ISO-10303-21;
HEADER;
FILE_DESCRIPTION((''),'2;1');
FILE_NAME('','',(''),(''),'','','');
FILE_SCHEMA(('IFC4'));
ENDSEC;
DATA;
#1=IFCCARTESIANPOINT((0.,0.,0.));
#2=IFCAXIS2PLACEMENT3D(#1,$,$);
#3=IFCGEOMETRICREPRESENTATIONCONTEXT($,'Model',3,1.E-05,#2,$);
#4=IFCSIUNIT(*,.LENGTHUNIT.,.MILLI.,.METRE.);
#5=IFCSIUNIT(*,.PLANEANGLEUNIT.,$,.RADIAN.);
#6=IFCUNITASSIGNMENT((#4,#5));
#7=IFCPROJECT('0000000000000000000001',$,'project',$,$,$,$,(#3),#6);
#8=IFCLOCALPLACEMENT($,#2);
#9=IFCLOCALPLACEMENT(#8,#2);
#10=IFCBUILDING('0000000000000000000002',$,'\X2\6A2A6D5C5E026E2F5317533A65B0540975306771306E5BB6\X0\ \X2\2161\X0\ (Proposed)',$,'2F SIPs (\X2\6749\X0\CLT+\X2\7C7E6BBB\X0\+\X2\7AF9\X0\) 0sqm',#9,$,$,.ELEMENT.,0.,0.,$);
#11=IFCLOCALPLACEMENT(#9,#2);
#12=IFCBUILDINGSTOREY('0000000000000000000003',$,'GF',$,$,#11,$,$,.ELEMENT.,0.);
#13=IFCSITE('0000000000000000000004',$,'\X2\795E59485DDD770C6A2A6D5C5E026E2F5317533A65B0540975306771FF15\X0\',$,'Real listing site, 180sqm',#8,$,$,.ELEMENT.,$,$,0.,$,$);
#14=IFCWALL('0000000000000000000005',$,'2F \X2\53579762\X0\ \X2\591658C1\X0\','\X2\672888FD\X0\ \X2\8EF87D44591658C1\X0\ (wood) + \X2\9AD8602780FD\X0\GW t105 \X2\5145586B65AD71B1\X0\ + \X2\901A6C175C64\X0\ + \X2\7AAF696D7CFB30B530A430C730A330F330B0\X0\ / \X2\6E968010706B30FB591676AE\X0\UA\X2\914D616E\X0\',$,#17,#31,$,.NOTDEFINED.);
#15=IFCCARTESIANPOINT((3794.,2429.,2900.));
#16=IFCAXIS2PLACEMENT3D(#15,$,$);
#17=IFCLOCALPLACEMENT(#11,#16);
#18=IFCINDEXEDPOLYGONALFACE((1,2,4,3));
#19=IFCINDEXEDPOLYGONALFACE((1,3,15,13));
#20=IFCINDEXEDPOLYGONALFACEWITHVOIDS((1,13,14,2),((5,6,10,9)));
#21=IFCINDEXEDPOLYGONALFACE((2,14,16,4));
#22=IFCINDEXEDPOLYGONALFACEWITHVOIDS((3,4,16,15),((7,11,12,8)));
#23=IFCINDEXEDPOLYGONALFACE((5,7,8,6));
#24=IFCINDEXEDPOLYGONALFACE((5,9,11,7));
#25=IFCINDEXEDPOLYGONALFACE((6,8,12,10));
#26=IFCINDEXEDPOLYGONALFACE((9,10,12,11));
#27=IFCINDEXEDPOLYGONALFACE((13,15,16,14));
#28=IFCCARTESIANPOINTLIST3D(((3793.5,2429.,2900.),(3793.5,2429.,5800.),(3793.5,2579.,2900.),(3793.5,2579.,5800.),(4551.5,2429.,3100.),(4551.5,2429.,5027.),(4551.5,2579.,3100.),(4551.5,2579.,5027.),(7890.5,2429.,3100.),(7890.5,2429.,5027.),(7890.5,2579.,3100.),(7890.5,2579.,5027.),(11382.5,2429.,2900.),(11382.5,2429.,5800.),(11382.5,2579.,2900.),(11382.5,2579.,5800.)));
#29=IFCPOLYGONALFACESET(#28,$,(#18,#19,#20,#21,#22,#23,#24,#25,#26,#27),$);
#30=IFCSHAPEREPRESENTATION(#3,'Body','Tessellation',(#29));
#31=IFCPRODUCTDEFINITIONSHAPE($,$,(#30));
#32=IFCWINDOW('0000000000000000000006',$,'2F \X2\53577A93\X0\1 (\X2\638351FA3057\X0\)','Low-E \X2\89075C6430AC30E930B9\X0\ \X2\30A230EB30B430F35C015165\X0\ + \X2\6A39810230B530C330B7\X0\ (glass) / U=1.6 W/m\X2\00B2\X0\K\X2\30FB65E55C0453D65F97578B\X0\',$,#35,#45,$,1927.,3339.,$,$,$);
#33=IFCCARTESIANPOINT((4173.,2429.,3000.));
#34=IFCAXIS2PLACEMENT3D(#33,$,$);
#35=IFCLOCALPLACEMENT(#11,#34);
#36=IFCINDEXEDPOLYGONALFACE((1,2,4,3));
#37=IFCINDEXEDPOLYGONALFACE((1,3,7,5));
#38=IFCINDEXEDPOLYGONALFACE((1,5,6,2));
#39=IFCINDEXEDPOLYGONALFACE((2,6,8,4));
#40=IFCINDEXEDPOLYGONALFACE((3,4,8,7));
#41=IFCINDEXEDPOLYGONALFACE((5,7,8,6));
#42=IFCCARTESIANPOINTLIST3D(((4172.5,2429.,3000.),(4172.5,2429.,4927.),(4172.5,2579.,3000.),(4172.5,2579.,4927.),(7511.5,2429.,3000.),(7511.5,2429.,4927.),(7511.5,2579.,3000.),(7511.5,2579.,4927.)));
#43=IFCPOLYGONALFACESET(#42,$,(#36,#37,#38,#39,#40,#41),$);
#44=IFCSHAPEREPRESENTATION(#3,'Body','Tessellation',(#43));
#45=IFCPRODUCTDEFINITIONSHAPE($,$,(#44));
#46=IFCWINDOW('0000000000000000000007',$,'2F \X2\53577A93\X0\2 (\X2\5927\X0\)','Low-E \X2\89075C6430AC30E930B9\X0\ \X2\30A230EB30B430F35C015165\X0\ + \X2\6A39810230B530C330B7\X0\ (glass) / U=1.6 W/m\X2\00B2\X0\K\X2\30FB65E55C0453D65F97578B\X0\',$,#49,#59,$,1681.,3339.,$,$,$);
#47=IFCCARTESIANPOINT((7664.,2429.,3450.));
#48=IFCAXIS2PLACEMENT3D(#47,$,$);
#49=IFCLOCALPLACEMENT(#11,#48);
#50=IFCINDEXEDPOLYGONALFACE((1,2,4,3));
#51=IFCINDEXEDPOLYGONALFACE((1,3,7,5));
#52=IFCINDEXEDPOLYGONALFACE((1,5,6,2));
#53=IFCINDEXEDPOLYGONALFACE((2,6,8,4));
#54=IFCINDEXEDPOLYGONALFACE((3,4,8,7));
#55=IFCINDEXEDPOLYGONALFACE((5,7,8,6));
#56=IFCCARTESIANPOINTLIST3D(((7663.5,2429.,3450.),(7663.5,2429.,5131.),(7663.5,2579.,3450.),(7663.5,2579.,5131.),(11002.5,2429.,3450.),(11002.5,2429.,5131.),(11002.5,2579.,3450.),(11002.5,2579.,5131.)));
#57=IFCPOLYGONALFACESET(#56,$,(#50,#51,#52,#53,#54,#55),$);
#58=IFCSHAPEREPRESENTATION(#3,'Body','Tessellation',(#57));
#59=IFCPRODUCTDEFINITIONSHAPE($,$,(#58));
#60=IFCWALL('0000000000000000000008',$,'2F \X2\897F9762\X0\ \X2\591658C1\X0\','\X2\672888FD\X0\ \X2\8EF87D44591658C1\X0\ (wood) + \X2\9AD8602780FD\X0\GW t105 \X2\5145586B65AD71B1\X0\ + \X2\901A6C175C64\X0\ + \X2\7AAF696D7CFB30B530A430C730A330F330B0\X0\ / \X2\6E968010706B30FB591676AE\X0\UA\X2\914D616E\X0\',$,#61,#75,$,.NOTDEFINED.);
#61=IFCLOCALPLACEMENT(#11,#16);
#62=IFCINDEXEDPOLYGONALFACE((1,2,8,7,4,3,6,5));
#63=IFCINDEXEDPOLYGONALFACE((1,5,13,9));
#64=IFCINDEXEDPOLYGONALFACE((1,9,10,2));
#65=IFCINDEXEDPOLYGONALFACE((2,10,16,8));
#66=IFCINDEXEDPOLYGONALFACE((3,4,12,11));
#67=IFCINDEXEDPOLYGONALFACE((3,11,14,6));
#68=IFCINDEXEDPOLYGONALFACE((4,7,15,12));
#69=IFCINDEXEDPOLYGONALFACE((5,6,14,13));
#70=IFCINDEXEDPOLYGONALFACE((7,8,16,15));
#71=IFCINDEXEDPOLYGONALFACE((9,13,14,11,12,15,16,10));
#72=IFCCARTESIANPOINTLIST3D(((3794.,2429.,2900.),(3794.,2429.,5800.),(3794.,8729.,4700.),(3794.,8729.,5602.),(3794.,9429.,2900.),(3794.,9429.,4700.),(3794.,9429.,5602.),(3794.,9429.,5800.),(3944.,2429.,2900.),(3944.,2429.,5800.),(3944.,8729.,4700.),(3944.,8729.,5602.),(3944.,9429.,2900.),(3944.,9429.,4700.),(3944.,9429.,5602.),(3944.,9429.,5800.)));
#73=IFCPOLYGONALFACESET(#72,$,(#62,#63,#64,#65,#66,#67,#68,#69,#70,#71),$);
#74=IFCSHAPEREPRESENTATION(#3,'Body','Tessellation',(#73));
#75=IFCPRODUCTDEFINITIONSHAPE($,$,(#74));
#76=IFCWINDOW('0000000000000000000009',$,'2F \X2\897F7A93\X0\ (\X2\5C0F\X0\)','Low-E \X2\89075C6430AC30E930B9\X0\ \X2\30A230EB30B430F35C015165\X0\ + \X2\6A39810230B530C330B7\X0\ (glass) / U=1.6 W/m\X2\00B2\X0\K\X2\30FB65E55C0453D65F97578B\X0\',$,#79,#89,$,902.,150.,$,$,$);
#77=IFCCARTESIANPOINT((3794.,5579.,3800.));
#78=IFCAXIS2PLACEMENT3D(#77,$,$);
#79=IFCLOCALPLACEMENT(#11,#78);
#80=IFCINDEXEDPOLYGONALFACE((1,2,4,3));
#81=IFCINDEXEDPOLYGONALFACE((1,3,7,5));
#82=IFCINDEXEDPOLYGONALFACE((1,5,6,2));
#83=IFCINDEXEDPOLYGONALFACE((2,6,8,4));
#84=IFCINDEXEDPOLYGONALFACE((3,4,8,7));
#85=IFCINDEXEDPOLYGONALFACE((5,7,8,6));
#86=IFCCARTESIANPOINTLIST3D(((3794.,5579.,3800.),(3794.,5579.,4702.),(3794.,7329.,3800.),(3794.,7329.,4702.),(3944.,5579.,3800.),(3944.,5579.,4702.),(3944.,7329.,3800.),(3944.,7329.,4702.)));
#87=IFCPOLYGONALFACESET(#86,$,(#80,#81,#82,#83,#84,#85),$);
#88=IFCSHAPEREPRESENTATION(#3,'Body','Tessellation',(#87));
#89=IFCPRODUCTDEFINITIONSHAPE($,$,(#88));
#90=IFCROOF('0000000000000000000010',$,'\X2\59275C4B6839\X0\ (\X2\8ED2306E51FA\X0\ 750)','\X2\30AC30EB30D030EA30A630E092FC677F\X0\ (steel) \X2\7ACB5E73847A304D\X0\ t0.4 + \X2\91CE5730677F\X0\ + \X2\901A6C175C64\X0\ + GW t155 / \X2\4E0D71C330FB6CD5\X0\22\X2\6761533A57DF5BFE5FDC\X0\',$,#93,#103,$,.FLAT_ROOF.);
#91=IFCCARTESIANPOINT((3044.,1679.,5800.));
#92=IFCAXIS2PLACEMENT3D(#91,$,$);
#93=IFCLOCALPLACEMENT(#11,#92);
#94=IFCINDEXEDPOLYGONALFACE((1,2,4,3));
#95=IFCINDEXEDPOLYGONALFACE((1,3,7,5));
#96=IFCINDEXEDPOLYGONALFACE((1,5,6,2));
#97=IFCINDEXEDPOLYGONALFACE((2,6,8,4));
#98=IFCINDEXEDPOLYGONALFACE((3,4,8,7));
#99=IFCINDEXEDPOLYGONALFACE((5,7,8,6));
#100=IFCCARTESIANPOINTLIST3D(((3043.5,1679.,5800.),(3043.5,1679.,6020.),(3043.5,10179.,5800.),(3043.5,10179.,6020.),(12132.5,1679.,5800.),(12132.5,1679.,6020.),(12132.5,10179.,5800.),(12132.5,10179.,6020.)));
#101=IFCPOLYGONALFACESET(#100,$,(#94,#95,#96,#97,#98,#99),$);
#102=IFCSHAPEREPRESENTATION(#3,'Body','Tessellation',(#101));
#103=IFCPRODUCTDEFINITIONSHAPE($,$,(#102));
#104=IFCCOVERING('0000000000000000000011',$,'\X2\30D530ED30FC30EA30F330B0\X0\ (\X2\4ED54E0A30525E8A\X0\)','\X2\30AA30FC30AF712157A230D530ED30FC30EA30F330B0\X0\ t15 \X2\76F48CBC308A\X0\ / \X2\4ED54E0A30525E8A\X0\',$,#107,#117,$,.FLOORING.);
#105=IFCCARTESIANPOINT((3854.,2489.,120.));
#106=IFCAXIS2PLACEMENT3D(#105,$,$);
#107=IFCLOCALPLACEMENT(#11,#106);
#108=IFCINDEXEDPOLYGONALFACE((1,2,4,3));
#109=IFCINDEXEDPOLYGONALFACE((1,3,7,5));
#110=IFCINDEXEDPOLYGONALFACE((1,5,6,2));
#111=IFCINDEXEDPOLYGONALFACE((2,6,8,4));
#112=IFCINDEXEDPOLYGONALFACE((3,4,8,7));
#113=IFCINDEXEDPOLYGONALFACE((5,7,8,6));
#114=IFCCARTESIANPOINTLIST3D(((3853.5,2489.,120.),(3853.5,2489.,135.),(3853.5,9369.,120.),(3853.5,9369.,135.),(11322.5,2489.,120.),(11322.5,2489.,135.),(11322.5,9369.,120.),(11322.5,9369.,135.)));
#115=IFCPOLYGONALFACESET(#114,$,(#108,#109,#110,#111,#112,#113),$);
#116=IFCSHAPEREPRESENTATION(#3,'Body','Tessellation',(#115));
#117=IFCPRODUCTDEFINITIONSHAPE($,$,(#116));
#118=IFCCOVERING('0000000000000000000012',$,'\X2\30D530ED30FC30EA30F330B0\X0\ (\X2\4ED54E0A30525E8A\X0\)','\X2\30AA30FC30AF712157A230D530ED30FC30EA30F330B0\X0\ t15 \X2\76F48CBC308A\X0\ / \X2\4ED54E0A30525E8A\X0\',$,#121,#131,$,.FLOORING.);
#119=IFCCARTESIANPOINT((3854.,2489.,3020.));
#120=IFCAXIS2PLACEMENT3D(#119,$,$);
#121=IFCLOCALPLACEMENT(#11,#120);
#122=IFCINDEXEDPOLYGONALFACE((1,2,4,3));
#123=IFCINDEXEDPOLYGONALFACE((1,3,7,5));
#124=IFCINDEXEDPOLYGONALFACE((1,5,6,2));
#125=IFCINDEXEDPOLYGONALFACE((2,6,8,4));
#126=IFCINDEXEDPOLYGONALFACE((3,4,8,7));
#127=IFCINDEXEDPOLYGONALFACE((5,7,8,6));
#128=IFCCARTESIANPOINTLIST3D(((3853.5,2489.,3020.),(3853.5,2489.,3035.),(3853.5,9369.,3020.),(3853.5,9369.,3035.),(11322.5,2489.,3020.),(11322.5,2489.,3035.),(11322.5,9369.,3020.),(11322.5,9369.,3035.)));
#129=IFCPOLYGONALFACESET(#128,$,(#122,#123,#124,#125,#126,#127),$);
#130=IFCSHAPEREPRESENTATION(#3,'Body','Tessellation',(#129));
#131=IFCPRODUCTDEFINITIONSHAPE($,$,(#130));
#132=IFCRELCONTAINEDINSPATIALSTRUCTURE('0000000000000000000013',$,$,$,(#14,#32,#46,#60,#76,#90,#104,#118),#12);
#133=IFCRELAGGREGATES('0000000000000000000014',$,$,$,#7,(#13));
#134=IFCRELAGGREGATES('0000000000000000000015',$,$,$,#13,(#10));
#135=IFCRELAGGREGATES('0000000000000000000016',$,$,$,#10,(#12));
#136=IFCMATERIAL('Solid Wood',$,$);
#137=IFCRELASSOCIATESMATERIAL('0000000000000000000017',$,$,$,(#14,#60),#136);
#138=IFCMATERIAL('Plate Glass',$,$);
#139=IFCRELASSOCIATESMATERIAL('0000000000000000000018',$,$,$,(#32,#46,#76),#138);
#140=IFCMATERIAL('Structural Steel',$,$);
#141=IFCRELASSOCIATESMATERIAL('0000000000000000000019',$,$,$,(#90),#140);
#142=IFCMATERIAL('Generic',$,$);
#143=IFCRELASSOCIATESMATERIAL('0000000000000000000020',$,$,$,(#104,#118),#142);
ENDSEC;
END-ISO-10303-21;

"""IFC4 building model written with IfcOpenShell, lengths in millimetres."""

from ifc_helpers import new_model, si_unit, frame, frame_2d, origin, place, context, project, spatial, rectangle, extrude, material, element, fill, save


model = new_model("IFC4")

# Units and contexts
model_context = context("Model", 3, precision=1e-05, world=origin())
ifc_project = project(units=[si_unit("LENGTHUNIT", "METRE", prefix="MILLI"), si_unit("PLANEANGLEUNIT", "RADIAN")], contexts=[model_context])

# Site, building, storey
site_placement = place(None, origin())
site = spatial("IfcSite", under=ifc_project, at=site_placement, Name="神奈川県横浜市港北区新吉田東５", ObjectType="Real listing site, 180sqm", CompositionType="ELEMENT", RefElevation=0.0)
building_placement = place(site_placement, origin())
building = spatial("IfcBuilding", under=site, at=building_placement, Name="横浜市港北区新吉田東の家 Ⅱ (Proposed)", ObjectType="2F SIPs (杉CLT+籾殻+竹) 0sqm", CompositionType="ELEMENT", ElevationOfRefHeight=0.0, ElevationOfTerrain=0.0)
storey_placement = place(building_placement, origin())
storey = spatial("IfcBuildingStorey", under=building, at=storey_placement, Name="GF", CompositionType="ELEMENT", Elevation=0.0)

# Shared definitions
ifc_material_1 = material(Name="Solid Wood")

# Shared definitions
ifc_material_2 = material(Name="Plate Glass")

# Wall, openings, windows
wall_1_placement = place(storey_placement, frame((3794.0, 2429.0, 2900.0)))
wall_1 = element("IfcWall", 1, at=wall_1_placement, inside=storey, material=ifc_material_1, Name="2F 南面 外壁", Description="木製 軸組外壁 (wood) + 高性能GW t105 充填断熱 + 通気層 + 窯業系サイディング / 準耐火・外皮UA配慮", PredefinedType="NOTDEFINED", context=model_context, shape_type="SweptSolid", body=[
    extrude(rectangle(XDim=7589.0, YDim=150.0, at=frame_2d((3794.0, 75.0))), frame((3794.0, 2429.0, 2900.0)), (0.0, 0.0, 1.0), 2900.0),
])
opening_1_placement = place(storey_placement, frame((4173.0, 2429.0, 3000.0)))
opening_1 = element("IfcOpeningElement", 2, at=opening_1_placement, cuts=wall_1, PredefinedType="NOTDEFINED", context=model_context, shape_type="SweptSolid", body=[
    extrude(rectangle(XDim=3339.0, YDim=150.0, at=frame_2d((1669.0, 75.0))), frame((4173.0, 2429.0, 3000.0)), (0.0, 0.0, 1.0), 1927.0),
])
opening_2_placement = place(storey_placement, frame((7664.0, 2429.0, 3450.0)))
opening_2 = element("IfcOpeningElement", 3, at=opening_2_placement, cuts=wall_1, PredefinedType="NOTDEFINED", context=model_context, shape_type="SweptSolid", body=[
    extrude(rectangle(XDim=3339.0, YDim=150.0, at=frame_2d((1669.0, 75.0))), frame((7664.0, 2429.0, 3450.0)), (0.0, 0.0, 1.0), 1681.0),
])
window_1_placement = place(storey_placement, frame((4173.0, 2429.0, 3000.0)))
window_1 = element("IfcWindow", 4, at=window_1_placement, inside=storey, material=ifc_material_2, Name="2F 南窓1 (掃出し)", Description="Low-E 複層ガラス アルゴン封入 + 樹脂サッシ (glass) / U=1.6 W/m²K・日射取得型", OverallHeight=1927.0, OverallWidth=3339.0, context=model_context, shape_type="SweptSolid", body=[
    extrude(rectangle(XDim=3339.0, YDim=150.0, at=frame_2d((1669.0, 75.0))), frame((4173.0, 2429.0, 3000.0)), (0.0, 0.0, 1.0), 1927.0),
])
fill(opening_1, window_1)
window_2_placement = place(storey_placement, frame((7664.0, 2429.0, 3450.0)))
window_2 = element("IfcWindow", 5, at=window_2_placement, inside=storey, material=ifc_material_2, Name="2F 南窓2 (大)", Description="Low-E 複層ガラス アルゴン封入 + 樹脂サッシ (glass) / U=1.6 W/m²K・日射取得型", OverallHeight=1681.0, OverallWidth=3339.0, context=model_context, shape_type="SweptSolid", body=[
    extrude(rectangle(XDim=3339.0, YDim=150.0, at=frame_2d((1669.0, 75.0))), frame((7664.0, 2429.0, 3450.0)), (0.0, 0.0, 1.0), 1681.0),
])
fill(opening_2, window_2)

# Wall, opening, window
wall_2_placement = place(storey_placement, frame((3794.0, 2429.0, 2900.0)))
wall_2 = element("IfcWall", 6, at=wall_2_placement, inside=storey, material=ifc_material_1, Name="2F 西面 外壁", Description="木製 軸組外壁 (wood) + 高性能GW t105 充填断熱 + 通気層 + 窯業系サイディング / 準耐火・外皮UA配慮", PredefinedType="NOTDEFINED", context=model_context, shape_type="SweptSolid", body=[
    extrude(rectangle(XDim=150.0, YDim=7000.0, at=frame_2d((75.0, 3500.0))), frame((3794.0, 2429.0, 2900.0)), (0.0, 0.0, 1.0), 2900.0),
])
opening_3_placement = place(storey_placement, frame((3794.0, 5579.0, 3800.0)))
opening_3 = element("IfcOpeningElement", 7, at=opening_3_placement, cuts=wall_2, PredefinedType="NOTDEFINED", context=model_context, shape_type="SweptSolid", body=[
    extrude(rectangle(XDim=150.0, YDim=1750.0, at=frame_2d((75.0, 875.0))), frame((3794.0, 5579.0, 3800.0)), (0.0, 0.0, 1.0), 902.0),
])
window_3_placement = place(storey_placement, frame((3794.0, 5579.0, 3800.0)))
window_3 = element("IfcWindow", 8, at=window_3_placement, inside=storey, material=ifc_material_2, Name="2F 西窓 (小)", Description="Low-E 複層ガラス アルゴン封入 + 樹脂サッシ (glass) / U=1.6 W/m²K・日射取得型", OverallHeight=902.0, OverallWidth=150.0, context=model_context, shape_type="SweptSolid", body=[
    extrude(rectangle(XDim=150.0, YDim=1750.0, at=frame_2d((75.0, 875.0))), frame((3794.0, 5579.0, 3800.0)), (0.0, 0.0, 1.0), 902.0),
])
fill(opening_3, window_3)

# Roof
ifc_material_3 = material(Name="Structural Steel")
roof_placement = place(storey_placement, frame((3044.0, 1679.0, 5800.0)))
element("IfcRoof", 9, at=roof_placement, inside=storey, material=ifc_material_3, Name="大屋根 (軒の出 750)", Description="ガルバリウム鋼板 (steel) 立平葺き t0.4 + 野地板 + 通気層 + GW t155 / 不燃・法22条区域対応", PredefinedType="FLAT_ROOF", context=model_context, shape_type="SweptSolid", body=[
    extrude(rectangle(XDim=9089.0, YDim=8500.0, at=frame_2d((4544.0, 4250.0))), frame((3044.0, 1679.0, 5800.0)), (0.0, 0.0, 1.0), 220.0),
])

# Coverings
ifc_material_4 = material(Name="Generic")
covering_1_placement = place(storey_placement, frame((3854.0, 2489.0, 120.0)))
element("IfcCovering", 10, at=covering_1_placement, inside=storey, material=ifc_material_4, Name="フローリング (仕上げ床)", Description="オーク無垢フローリング t15 直貼り / 仕上げ床", PredefinedType="FLOORING", context=model_context, shape_type="SweptSolid", body=[
    extrude(rectangle(XDim=7469.0, YDim=6880.0, at=frame_2d((3734.0, 3440.0))), frame((3854.0, 2489.0, 120.0)), (0.0, 0.0, 1.0), 15.0),
])
covering_2_placement = place(storey_placement, frame((3854.0, 2489.0, 3020.0)))
element("IfcCovering", 11, at=covering_2_placement, inside=storey, material=ifc_material_4, Name="フローリング (仕上げ床)", Description="オーク無垢フローリング t15 直貼り / 仕上げ床", PredefinedType="FLOORING", context=model_context, shape_type="SweptSolid", body=[
    extrude(rectangle(XDim=7469.0, YDim=6880.0, at=frame_2d((3734.0, 3440.0))), frame((3854.0, 2489.0, 3020.0)), (0.0, 0.0, 1.0), 15.0),
])

save(model, "model.ifc")
